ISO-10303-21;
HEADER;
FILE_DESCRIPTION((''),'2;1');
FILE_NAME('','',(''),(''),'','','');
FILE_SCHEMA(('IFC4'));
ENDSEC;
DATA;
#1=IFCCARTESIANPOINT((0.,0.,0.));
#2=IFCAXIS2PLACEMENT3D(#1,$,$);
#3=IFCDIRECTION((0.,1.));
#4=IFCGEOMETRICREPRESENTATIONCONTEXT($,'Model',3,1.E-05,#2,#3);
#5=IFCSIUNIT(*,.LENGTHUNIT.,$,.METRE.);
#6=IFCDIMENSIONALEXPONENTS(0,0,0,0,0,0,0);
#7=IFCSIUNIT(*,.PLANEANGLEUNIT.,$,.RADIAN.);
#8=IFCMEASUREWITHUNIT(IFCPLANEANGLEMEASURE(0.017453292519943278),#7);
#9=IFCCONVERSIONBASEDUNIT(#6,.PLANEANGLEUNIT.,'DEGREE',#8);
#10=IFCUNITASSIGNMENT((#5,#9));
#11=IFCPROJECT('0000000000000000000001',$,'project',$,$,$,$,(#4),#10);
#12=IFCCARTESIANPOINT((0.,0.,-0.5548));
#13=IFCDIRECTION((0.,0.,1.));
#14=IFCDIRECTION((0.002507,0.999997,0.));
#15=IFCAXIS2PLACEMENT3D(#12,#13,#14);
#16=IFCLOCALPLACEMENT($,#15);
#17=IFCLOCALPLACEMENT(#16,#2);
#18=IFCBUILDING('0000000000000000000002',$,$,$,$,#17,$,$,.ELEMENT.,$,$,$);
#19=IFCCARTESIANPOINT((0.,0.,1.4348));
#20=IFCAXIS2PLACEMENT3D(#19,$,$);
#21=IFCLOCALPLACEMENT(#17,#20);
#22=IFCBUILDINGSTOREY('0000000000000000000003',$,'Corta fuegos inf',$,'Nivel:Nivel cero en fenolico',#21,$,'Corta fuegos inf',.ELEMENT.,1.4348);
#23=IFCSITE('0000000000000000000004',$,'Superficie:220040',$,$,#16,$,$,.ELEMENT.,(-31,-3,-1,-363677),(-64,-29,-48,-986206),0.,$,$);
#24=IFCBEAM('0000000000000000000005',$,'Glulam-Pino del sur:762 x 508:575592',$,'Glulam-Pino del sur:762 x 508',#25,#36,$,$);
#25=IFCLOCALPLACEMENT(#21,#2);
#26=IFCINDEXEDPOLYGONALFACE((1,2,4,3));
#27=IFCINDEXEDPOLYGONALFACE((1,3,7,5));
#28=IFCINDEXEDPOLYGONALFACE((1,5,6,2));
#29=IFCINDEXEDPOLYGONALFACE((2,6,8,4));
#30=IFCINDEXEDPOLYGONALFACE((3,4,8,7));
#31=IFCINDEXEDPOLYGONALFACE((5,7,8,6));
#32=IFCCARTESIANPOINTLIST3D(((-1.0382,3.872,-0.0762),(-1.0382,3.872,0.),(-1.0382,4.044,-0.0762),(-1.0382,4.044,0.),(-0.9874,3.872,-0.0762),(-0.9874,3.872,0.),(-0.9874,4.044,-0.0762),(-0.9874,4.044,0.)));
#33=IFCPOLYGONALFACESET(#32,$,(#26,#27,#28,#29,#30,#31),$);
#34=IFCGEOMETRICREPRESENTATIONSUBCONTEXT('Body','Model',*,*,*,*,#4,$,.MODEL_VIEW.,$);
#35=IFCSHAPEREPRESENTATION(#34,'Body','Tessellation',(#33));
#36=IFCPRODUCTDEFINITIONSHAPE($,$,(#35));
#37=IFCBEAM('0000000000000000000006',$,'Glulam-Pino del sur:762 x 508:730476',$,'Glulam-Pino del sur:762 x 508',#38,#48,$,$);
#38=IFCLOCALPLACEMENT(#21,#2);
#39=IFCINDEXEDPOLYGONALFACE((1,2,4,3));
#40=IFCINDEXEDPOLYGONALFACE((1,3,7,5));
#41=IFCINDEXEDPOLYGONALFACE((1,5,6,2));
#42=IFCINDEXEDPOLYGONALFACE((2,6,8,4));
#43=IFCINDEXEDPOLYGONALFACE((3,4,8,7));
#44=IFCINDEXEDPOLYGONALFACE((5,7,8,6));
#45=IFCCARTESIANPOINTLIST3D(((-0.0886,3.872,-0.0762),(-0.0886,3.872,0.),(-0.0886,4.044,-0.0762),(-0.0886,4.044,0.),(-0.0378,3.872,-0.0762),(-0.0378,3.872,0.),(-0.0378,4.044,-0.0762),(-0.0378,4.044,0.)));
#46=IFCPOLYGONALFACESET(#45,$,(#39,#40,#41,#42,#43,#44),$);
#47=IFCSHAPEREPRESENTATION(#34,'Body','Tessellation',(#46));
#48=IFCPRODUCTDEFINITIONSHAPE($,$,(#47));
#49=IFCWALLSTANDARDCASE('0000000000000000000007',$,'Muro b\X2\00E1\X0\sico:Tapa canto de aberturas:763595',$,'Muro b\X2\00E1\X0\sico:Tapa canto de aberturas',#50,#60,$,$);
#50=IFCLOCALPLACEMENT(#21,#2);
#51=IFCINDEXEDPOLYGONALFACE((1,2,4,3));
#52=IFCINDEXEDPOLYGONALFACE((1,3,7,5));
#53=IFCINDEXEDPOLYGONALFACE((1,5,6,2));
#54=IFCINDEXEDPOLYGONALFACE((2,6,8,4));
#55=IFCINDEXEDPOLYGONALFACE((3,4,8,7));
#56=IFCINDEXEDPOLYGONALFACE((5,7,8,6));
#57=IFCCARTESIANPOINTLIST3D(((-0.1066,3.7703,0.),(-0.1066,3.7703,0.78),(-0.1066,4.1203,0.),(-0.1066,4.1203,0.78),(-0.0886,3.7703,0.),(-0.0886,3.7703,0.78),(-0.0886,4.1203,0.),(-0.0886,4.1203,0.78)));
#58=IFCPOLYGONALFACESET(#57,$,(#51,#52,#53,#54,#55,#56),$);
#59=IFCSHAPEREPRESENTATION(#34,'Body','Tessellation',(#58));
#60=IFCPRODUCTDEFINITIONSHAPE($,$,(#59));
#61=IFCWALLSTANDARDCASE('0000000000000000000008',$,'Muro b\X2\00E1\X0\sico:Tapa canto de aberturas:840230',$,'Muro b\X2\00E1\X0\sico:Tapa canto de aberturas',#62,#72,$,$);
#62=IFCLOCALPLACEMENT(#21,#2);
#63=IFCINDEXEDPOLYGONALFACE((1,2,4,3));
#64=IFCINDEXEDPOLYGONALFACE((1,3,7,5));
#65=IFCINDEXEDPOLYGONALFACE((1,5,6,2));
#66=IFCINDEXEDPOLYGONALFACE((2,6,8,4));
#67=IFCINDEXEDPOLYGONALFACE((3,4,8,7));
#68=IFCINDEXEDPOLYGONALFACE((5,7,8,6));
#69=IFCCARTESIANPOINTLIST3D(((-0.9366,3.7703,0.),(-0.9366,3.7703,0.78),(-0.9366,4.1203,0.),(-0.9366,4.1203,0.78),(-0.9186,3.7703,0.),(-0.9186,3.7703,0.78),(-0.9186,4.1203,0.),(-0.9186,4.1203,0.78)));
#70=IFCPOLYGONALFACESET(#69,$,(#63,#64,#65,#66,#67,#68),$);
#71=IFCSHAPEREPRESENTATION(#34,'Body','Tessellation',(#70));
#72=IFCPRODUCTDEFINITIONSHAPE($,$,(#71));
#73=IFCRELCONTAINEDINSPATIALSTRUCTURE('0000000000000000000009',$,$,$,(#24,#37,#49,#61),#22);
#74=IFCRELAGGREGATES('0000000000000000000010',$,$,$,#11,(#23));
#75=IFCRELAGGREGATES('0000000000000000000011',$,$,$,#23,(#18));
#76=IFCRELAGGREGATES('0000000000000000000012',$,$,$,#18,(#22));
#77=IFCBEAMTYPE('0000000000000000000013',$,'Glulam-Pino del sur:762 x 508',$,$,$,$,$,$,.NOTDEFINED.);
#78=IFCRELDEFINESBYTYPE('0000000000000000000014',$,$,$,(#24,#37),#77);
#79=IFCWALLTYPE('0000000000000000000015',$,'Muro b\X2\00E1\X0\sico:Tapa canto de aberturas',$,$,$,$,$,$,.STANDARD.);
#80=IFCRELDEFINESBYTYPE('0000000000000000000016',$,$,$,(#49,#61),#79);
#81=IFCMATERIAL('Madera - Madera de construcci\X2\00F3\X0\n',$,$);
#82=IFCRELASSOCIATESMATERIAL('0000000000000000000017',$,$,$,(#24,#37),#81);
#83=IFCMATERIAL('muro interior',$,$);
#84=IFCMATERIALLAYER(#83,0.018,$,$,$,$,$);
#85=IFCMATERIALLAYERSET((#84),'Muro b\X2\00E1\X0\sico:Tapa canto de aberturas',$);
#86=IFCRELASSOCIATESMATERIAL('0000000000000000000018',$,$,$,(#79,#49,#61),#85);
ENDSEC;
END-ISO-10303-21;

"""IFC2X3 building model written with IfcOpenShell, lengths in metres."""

from ifc_helpers import new_model, entity, si_unit, converted_unit, direction, frame, frame_2d, origin, origin_2d_with_axis, place, context, subcontext, project, spatial, rectangle, extrude, clip, halfspace, material, layer, layer_set, layer_usage, type_object, element, save


model = new_model("IFC2X3")

# Units and contexts
model_context = context("Model", 3, precision=1e-05, world=origin(), true_north=direction((0.0, 1.0)))
body_context = subcontext(model_context, "Body", "Model", "MODEL_VIEW")
ifc_project = project(units=[si_unit("LENGTHUNIT", "METRE"), converted_unit("PLANEANGLEUNIT", "DEGREE", entity("IfcPlaneAngleMeasure", 0.017453292519943278), si_unit("PLANEANGLEUNIT", "RADIAN"), dimensions=[0, 0, 0, 0, 0, 0, 0])], contexts=[model_context])

# Site, building, storey
site_placement = place(None, frame((0.0, 0.0, -0.5548), z_axis=(0.0, 0.0, 1.0), x_axis=(0.002507, 0.999997, 0.0)))
site = spatial("IfcSite", under=ifc_project, at=site_placement, Name="Superficie:220040", CompositionType="ELEMENT", RefLatitude=(-31, -3, -1, -363677), RefLongitude=(-64, -29, -48, -986206), RefElevation=0.0)
building_placement = place(site_placement, origin())
building = spatial("IfcBuilding", under=site, at=building_placement, CompositionType="ELEMENT")
storey_placement = place(building_placement, frame((0.0, 0.0, 1.4348)))
storey = spatial("IfcBuildingStorey", under=building, at=storey_placement, Name="Corta fuegos inf", ObjectType="Nivel:Nivel cero en fenolico", LongName="Corta fuegos inf", CompositionType="ELEMENT", Elevation=1.4348)

# Shared definitions
ifc_material_1 = material(Name="Madera - Madera de construcción")

# Beams
beam_type_1 = type_object("IfcBeamType", Name="Glulam-Pino del sur:762 x 508", PredefinedType="NOTDEFINED")
beam_1_placement = place(storey_placement, frame((-1.0128, 3.8719, 0.0), z_axis=(0.0, 0.0, 1.0), x_axis=(0.0, 1.0, 0.0)))
element("IfcBeam", 1, at=beam_1_placement, inside=storey, type_object=beam_type_1, material=ifc_material_1, Name="Glulam-Pino del sur:762 x 508:575592", ObjectType="Glulam-Pino del sur:762 x 508", context=body_context, shape_type="SweptSolid", body=[
    extrude(rectangle(XDim=0.0762, YDim=0.0508, at=origin_2d_with_axis()), frame((0.0001, 0.0, -0.0381), z_axis=(1.0, 0.0, 0.0), x_axis=(0.0, 0.0, -1.0)), (0.0, 0.0, 1.0), 0.172),
])
beam_2_placement = place(storey_placement, frame((-0.0632, 3.8719, 0.0), z_axis=(0.0, 0.0, 1.0), x_axis=(0.0, 1.0, 0.0)))
element("IfcBeam", 2, at=beam_2_placement, inside=storey, type_object=beam_type_1, material=ifc_material_1, Name="Glulam-Pino del sur:762 x 508:730476", ObjectType="Glulam-Pino del sur:762 x 508", context=body_context, shape_type="SweptSolid", body=[
    extrude(rectangle(XDim=0.0762, YDim=0.0508, at=frame_2d((0.0, 0.0), x_axis=(1.0, 0.0))), frame((0.0001, 0.0, -0.0381), z_axis=(1.0, 0.0, 0.0), x_axis=(0.0, 0.0, -1.0)), (0.0, 0.0, 1.0), 0.172),
])

# Walls
ifc_material_2 = material(Name="muro interior")
ifc_layer_1 = layer(ifc_material_2, 0.018)
ifc_layer_set_1 = layer_set([ifc_layer_1], Name="Muro básico:Tapa canto de aberturas")
ifc_layer_usage_1 = layer_usage(ifc_layer_set_1, "AXIS2", "POSITIVE", -0.009)
wall_type_1 = type_object("IfcWallType", Name="Muro básico:Tapa canto de aberturas", PredefinedType="STANDARD", material=ifc_layer_set_1)
wall_1_placement = place(storey_placement, frame((-0.0976, 3.7703, 0.0), z_axis=(0.0, 0.0, 1.0), x_axis=(0.0, 1.0, 0.0)))
element("IfcWallStandardCase", 3, at=wall_1_placement, inside=storey, type_object=wall_type_1, material=ifc_layer_usage_1, Name="Muro básico:Tapa canto de aberturas:763595", ObjectType="Muro básico:Tapa canto de aberturas", context=body_context, shape_type="Clipping", body=[
    clip(extrude(rectangle(XDim=0.35, YDim=0.018, at=frame_2d((0.175, 0.0), x_axis=(-1.0, 0.0))), origin(), (0.0, 0.0, 1.0), 0.78), halfspace(frame((0.0, 0.0, -1.384)), True)),
])
ifc_layer_usage_2 = layer_usage(ifc_layer_set_1, "AXIS2", "NEGATIVE", 0.009)
wall_2_placement = place(storey_placement, frame((-0.9276, 3.7703, 0.0), z_axis=(0.0, 0.0, 1.0), x_axis=(0.0, 1.0, 0.0)))
element("IfcWallStandardCase", 4, at=wall_2_placement, inside=storey, type_object=wall_type_1, material=ifc_layer_usage_2, Name="Muro básico:Tapa canto de aberturas:840230", ObjectType="Muro básico:Tapa canto de aberturas", context=body_context, shape_type="Clipping", body=[
    clip(extrude(rectangle(XDim=0.35, YDim=0.018, at=frame_2d((0.175, 0.0), x_axis=(-1.0, 0.0))), origin(), (0.0, 0.0, 1.0), 0.78), halfspace(frame((0.0, 0.0, -1.384)), True)),
])

save(model, "model.ifc")
